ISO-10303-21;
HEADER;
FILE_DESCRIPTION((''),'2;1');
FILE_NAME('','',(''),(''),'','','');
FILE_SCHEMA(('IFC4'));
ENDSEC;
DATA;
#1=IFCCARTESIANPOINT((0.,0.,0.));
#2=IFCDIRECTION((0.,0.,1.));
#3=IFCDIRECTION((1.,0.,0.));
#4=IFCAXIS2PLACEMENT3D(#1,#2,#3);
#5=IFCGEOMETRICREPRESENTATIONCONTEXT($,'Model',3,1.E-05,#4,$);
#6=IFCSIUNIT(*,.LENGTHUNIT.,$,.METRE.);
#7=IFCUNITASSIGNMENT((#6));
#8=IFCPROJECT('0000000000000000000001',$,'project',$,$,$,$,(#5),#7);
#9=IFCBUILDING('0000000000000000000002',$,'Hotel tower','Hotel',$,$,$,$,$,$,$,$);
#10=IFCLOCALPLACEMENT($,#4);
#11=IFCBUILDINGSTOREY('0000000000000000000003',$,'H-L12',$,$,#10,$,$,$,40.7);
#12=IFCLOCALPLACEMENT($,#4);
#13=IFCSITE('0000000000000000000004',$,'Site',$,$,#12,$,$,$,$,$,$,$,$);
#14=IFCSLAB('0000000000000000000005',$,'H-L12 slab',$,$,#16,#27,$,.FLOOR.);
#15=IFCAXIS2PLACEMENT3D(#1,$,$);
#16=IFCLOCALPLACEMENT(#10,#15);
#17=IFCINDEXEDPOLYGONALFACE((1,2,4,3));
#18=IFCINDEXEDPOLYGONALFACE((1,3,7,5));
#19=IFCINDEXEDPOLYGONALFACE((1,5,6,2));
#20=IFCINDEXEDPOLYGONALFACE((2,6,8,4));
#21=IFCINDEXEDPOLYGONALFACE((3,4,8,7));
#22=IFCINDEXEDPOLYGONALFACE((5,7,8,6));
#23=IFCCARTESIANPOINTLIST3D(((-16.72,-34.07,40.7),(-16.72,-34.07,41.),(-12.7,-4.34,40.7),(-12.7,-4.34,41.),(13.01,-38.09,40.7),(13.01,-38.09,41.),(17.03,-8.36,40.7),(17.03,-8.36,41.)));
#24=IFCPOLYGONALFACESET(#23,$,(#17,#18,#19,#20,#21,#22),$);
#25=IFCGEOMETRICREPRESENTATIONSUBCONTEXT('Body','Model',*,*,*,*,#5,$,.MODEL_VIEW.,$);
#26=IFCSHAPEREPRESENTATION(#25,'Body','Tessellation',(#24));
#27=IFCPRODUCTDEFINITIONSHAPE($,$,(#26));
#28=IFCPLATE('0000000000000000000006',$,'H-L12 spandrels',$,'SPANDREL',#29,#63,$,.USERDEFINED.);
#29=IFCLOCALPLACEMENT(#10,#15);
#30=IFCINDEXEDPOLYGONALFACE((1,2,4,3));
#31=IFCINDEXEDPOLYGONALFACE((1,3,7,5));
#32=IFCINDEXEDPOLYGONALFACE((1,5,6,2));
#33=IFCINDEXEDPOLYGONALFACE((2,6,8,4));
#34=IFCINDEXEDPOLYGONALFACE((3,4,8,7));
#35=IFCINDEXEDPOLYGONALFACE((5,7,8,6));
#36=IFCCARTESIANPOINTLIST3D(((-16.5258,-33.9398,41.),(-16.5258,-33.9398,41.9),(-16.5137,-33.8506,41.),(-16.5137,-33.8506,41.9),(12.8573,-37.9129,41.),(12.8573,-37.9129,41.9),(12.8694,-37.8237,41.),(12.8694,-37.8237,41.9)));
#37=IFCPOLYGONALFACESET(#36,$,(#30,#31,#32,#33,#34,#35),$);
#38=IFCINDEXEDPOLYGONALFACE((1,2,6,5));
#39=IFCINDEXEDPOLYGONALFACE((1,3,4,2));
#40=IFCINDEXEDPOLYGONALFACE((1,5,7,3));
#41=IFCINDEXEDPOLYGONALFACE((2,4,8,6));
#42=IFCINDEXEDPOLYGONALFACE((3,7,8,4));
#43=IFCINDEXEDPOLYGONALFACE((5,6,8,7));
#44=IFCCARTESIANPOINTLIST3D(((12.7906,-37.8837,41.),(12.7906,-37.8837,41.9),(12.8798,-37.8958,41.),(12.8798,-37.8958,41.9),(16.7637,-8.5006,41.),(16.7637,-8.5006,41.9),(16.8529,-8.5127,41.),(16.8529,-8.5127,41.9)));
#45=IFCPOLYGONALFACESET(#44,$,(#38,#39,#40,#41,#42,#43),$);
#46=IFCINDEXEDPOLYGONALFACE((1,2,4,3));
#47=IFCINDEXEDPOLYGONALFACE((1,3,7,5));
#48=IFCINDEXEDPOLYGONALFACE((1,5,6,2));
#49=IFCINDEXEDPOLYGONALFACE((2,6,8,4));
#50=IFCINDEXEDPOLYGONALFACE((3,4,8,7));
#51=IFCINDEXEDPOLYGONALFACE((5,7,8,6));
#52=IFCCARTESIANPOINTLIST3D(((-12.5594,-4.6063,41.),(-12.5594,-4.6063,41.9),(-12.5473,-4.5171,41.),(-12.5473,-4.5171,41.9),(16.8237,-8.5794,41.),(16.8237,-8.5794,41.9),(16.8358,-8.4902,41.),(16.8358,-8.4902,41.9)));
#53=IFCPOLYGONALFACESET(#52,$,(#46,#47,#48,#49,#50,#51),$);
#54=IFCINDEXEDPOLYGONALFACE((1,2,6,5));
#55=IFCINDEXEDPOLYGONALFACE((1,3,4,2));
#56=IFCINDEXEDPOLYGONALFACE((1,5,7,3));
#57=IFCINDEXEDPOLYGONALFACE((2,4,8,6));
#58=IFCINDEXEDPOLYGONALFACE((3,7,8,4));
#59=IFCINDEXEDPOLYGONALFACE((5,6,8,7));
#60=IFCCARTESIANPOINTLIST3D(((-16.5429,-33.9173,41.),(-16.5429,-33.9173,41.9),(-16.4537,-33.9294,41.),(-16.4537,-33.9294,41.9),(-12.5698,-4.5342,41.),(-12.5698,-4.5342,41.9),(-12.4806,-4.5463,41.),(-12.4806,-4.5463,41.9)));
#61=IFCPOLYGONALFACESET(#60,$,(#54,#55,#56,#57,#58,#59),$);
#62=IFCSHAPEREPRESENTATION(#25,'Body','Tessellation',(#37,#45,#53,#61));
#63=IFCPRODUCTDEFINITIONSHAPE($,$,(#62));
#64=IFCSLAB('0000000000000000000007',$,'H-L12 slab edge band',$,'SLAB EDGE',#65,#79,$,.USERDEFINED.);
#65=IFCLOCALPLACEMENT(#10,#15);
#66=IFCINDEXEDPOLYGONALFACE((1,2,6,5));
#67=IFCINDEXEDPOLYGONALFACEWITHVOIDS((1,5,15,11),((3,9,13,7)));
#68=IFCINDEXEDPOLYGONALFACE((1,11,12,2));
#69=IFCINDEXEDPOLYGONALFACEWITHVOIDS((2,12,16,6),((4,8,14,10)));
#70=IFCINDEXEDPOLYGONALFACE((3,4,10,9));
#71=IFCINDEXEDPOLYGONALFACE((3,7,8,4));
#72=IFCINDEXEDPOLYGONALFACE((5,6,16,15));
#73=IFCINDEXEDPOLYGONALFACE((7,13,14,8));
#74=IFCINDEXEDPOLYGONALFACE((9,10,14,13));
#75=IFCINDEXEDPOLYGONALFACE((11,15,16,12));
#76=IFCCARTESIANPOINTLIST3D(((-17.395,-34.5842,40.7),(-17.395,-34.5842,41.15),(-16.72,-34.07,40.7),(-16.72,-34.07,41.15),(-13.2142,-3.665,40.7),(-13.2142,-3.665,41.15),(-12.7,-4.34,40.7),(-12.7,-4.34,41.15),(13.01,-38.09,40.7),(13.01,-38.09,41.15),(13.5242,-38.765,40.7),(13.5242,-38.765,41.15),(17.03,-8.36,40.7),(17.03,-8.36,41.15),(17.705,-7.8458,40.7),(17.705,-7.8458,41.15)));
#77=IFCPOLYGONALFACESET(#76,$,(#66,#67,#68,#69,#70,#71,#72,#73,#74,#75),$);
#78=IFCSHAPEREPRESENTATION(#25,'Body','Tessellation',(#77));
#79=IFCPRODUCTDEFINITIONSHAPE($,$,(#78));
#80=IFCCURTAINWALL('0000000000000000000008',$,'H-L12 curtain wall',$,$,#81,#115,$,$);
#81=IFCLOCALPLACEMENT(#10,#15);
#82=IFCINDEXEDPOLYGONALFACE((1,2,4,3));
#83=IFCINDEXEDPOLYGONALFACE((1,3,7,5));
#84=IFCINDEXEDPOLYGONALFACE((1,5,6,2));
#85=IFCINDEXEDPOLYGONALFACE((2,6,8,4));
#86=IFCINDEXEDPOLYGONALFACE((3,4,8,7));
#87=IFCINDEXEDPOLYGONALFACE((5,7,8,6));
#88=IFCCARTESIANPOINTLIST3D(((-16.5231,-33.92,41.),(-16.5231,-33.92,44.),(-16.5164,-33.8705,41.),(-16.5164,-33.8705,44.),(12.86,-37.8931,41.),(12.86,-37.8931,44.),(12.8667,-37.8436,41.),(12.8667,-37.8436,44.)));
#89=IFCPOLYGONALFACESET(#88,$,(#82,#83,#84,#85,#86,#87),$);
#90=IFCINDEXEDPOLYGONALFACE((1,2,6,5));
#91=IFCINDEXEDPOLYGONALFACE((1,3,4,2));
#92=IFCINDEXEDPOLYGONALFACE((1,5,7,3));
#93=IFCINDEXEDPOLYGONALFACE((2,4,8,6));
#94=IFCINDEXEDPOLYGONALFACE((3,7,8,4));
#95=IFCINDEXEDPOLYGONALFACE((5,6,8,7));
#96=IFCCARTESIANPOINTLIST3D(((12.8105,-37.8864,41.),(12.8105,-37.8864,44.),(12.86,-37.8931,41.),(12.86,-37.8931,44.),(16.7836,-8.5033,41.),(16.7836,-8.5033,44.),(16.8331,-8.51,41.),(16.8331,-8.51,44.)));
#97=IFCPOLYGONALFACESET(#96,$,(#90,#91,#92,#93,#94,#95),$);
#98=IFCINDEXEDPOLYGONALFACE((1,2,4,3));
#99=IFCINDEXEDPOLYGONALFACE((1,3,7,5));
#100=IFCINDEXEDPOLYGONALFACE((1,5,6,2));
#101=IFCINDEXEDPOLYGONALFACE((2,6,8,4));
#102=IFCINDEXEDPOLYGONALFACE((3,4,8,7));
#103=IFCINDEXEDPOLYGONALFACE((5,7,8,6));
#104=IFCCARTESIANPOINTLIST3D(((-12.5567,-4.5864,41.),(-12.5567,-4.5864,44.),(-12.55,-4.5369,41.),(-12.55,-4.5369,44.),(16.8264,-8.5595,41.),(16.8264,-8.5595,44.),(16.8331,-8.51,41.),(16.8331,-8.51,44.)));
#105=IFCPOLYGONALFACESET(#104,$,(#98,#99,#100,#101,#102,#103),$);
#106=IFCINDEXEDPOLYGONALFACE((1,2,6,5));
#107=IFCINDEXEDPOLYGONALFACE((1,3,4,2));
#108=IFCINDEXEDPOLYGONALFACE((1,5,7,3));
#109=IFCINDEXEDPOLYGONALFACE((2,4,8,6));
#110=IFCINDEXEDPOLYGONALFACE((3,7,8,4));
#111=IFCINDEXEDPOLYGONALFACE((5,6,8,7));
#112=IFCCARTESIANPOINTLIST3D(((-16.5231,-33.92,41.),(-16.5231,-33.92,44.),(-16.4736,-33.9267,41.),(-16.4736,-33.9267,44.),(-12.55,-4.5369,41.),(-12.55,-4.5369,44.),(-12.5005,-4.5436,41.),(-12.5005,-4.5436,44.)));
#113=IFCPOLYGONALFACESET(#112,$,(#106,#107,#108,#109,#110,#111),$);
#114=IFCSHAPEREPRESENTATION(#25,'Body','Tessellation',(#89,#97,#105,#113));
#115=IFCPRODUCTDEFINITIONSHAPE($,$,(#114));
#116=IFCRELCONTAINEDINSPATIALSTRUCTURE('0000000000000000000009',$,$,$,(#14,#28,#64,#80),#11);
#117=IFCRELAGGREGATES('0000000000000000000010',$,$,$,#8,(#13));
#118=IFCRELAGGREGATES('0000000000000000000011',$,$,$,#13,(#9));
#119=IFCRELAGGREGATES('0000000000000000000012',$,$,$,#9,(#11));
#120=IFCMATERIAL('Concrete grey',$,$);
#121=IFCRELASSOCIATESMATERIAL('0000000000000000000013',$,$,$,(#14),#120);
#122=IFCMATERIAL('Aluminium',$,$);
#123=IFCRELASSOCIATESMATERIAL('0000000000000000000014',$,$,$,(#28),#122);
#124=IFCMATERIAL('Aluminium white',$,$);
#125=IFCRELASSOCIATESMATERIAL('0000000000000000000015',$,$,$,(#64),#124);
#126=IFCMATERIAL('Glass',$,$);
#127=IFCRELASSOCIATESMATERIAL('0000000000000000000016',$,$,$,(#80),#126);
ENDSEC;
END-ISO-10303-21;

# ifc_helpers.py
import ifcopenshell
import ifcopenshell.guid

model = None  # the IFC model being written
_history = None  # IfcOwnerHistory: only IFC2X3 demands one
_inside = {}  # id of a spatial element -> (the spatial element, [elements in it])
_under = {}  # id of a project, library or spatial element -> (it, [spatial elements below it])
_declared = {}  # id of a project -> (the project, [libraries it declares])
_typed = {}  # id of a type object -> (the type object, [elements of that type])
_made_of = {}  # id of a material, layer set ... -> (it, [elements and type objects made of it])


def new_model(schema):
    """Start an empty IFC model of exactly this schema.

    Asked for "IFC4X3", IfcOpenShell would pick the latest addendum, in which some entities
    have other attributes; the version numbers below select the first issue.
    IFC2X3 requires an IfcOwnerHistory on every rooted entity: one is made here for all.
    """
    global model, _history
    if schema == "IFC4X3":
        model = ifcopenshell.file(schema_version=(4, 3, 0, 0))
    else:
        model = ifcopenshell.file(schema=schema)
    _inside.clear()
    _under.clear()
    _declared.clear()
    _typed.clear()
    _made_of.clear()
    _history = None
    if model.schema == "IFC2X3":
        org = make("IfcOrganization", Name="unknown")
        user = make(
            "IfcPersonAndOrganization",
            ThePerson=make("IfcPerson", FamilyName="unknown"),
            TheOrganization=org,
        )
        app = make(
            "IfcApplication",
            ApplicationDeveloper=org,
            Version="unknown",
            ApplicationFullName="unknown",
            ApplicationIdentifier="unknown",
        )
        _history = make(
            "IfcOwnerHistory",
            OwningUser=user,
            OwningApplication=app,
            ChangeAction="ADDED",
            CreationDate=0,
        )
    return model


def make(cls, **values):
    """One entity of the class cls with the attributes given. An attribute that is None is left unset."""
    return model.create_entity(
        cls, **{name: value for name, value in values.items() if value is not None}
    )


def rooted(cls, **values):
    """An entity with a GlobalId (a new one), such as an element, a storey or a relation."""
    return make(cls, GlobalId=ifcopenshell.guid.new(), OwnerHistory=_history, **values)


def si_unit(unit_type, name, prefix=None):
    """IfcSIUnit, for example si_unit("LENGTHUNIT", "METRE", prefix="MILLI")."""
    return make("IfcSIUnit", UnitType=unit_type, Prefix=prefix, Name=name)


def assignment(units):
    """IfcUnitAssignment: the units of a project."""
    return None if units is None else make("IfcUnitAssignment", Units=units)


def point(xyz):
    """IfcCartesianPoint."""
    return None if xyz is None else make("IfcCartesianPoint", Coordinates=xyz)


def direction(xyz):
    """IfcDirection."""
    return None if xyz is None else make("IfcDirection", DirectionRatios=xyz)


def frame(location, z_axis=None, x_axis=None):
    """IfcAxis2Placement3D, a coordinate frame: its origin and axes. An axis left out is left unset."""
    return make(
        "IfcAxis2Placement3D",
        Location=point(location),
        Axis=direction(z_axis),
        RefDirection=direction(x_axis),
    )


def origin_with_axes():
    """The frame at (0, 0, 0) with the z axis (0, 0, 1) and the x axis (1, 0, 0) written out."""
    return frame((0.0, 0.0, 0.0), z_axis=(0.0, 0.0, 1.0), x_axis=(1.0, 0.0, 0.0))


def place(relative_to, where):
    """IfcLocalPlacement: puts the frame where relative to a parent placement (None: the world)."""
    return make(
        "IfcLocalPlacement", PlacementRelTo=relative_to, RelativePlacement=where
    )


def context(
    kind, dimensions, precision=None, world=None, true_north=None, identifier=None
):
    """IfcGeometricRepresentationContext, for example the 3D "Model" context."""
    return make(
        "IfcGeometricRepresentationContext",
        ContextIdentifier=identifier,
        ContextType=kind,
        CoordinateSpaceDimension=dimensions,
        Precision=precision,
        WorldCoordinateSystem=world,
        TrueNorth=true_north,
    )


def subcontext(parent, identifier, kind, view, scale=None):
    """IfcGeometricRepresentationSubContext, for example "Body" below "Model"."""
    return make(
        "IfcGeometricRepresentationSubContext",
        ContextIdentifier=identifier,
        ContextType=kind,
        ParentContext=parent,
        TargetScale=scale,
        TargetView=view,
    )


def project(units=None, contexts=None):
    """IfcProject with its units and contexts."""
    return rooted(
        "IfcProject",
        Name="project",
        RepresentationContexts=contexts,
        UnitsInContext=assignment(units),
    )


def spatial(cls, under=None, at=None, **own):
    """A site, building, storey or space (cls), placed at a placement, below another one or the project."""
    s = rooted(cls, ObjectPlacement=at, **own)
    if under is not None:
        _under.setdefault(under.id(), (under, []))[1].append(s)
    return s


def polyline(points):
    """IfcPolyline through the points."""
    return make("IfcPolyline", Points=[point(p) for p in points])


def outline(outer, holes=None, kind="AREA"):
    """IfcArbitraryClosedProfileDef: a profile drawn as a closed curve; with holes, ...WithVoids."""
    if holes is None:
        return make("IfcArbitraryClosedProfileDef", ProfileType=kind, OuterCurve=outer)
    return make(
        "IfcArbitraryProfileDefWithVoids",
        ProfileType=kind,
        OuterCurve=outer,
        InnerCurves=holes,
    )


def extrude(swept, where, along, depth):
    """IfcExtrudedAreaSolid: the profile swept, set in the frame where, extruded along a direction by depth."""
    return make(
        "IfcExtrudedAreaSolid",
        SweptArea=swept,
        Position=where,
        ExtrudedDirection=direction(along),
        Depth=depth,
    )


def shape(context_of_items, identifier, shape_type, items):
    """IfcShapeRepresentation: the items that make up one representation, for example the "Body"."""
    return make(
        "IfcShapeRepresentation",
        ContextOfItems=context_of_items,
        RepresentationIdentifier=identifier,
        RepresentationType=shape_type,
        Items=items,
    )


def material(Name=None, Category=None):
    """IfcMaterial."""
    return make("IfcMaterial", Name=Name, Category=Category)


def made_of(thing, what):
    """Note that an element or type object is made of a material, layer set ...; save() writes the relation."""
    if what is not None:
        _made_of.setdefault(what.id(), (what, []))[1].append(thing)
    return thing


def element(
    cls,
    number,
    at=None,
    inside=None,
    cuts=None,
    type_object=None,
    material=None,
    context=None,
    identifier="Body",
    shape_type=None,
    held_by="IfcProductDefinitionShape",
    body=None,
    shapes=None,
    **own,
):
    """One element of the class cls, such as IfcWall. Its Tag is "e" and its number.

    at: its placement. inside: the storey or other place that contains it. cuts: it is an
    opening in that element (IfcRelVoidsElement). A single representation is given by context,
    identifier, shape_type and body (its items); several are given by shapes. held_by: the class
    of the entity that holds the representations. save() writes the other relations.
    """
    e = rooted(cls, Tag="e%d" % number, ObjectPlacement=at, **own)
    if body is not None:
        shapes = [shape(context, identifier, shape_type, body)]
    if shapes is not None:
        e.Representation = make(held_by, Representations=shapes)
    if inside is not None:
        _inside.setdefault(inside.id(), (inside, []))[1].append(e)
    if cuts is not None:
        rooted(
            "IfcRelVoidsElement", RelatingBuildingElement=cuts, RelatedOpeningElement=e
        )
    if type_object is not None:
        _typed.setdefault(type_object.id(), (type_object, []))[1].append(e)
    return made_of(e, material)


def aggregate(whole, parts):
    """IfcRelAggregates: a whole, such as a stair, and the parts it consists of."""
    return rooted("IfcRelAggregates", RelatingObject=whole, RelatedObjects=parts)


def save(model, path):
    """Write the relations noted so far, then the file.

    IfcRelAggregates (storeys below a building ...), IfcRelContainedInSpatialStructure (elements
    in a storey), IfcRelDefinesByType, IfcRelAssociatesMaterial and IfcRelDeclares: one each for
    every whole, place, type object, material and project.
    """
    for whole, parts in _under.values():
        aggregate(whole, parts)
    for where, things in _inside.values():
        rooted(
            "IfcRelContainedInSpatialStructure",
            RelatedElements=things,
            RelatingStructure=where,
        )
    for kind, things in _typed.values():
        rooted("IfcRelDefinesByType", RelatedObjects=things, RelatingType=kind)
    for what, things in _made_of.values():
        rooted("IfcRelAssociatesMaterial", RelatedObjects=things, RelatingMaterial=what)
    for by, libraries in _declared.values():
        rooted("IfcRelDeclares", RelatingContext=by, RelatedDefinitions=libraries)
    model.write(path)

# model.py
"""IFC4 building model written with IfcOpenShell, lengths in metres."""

from ifc_helpers import new_model, si_unit, frame, origin_with_axes, place, context, subcontext, project, spatial, polyline, outline, extrude, material, element, save


model = new_model("IFC4")

# Units and contexts
model_context = context("Model", 3, precision=1e-05, world=origin_with_axes())
body_context = subcontext(model_context, "Body", "Model", "MODEL_VIEW")
ifc_project = project(units=[si_unit("LENGTHUNIT", "METRE")], contexts=[model_context])

# Site, building, storey
site_placement = place(None, origin_with_axes())
site = spatial("IfcSite", under=ifc_project, at=site_placement, Name="Site")
building = spatial("IfcBuilding", under=site, Name="Hotel tower", Description="Hotel")
storey_placement = place(None, origin_with_axes())
storey = spatial("IfcBuildingStorey", under=building, at=storey_placement, Name="H-L12", Elevation=40.7)

# Shared definitions
ifc_material_1 = material(Name="Aluminium")

# Slab
ifc_material_2 = material(Name="Concrete grey")
slab_1_placement = place(storey_placement, origin_with_axes())
element("IfcSlab", 1, at=slab_1_placement, inside=storey, material=ifc_material_2, Name="H-L12 slab", PredefinedType="FLOOR", context=body_context, shape_type="SweptSolid", body=[
    extrude(outline(polyline([(-16.72, -34.07), (13.01, -38.09), (17.03, -8.36), (-12.7, -4.34), (-16.72, -34.07)])), frame((0.0, 0.0, 40.7), z_axis=(0.0, 0.0, 1.0), x_axis=(1.0, 0.0, 0.0)), (0.0, 0.0, 1.0), 0.3),
])

# Plate
plate_placement = place(storey_placement, origin_with_axes())
element("IfcPlate", 2, at=plate_placement, inside=storey, material=ifc_material_1, Name="H-L12 spandrels", ObjectType="SPANDREL", PredefinedType="USERDEFINED", context=body_context, shape_type="SweptSolid", body=[
    extrude(outline(polyline([(-16.5258, -33.9398), (12.8573, -37.9129), (12.8694, -37.8237), (-16.5137, -33.8506), (-16.5258, -33.9398)])), frame((0.0, 0.0, 41.0), z_axis=(0.0, 0.0, 1.0), x_axis=(1.0, 0.0, 0.0)), (0.0, 0.0, 1.0), 0.9),
    extrude(outline(polyline([(12.8798, -37.8958), (16.8529, -8.5127), (16.7637, -8.5006), (12.7906, -37.8837), (12.8798, -37.8958)])), frame((0.0, 0.0, 41.0), z_axis=(0.0, 0.0, 1.0), x_axis=(1.0, 0.0, 0.0)), (0.0, 0.0, 1.0), 0.9),
    extrude(outline(polyline([(16.8358, -8.4902), (-12.5473, -4.5171), (-12.5594, -4.6063), (16.8237, -8.5794), (16.8358, -8.4902)])), frame((0.0, 0.0, 41.0), z_axis=(0.0, 0.0, 1.0), x_axis=(1.0, 0.0, 0.0)), (0.0, 0.0, 1.0), 0.9),
    extrude(outline(polyline([(-12.5698, -4.5342), (-16.5429, -33.9173), (-16.4537, -33.9294), (-12.4806, -4.5463), (-12.5698, -4.5342)])), frame((0.0, 0.0, 41.0), z_axis=(0.0, 0.0, 1.0), x_axis=(1.0, 0.0, 0.0)), (0.0, 0.0, 1.0), 0.9),
])

# Slab
ifc_material_3 = material(Name="Aluminium white")
slab_2_placement = place(storey_placement, origin_with_axes())
element("IfcSlab", 3, at=slab_2_placement, inside=storey, material=ifc_material_3, Name="H-L12 slab edge band", ObjectType="SLAB EDGE", PredefinedType="USERDEFINED", context=body_context, shape_type="SweptSolid", body=[
    extrude(outline(polyline([(-17.395, -34.5842), (13.5242, -38.765), (17.705, -7.8458), (-13.2142, -3.665), (-17.395, -34.5842)]), holes=[polyline([(-16.72, -34.07), (13.01, -38.09), (17.03, -8.36), (-12.7, -4.34), (-16.72, -34.07)])]), frame((0.0, 0.0, 40.7), z_axis=(0.0, 0.0, 1.0), x_axis=(1.0, 0.0, 0.0)), (0.0, 0.0, 1.0), 0.45),
])

# Curtain wall
ifc_material_4 = material(Name="Glass")
curtain_wall_placement = place(storey_placement, origin_with_axes())
element("IfcCurtainWall", 4, at=curtain_wall_placement, inside=storey, material=ifc_material_4, Name="H-L12 curtain wall", context=body_context, shape_type="SweptSolid", body=[
    extrude(outline(polyline([(-16.5231, -33.92), (12.86, -37.8931), (12.8667, -37.8436), (-16.5164, -33.8705), (-16.5231, -33.92)])), frame((0.0, 0.0, 41.0), z_axis=(0.0, 0.0, 1.0), x_axis=(1.0, 0.0, 0.0)), (0.0, 0.0, 1.0), 3.0),
    extrude(outline(polyline([(12.86, -37.8931), (16.8331, -8.51), (16.7836, -8.5033), (12.8105, -37.8864), (12.86, -37.8931)])), frame((0.0, 0.0, 41.0), z_axis=(0.0, 0.0, 1.0), x_axis=(1.0, 0.0, 0.0)), (0.0, 0.0, 1.0), 3.0),
    extrude(outline(polyline([(16.8331, -8.51), (-12.55, -4.5369), (-12.5567, -4.5864), (16.8264, -8.5595), (16.8331, -8.51)])), frame((0.0, 0.0, 41.0), z_axis=(0.0, 0.0, 1.0), x_axis=(1.0, 0.0, 0.0)), (0.0, 0.0, 1.0), 3.0),
    extrude(outline(polyline([(-12.55, -4.5369), (-16.5231, -33.92), (-16.4736, -33.9267), (-12.5005, -4.5436), (-12.55, -4.5369)])), frame((0.0, 0.0, 41.0), z_axis=(0.0, 0.0, 1.0), x_axis=(1.0, 0.0, 0.0)), (0.0, 0.0, 1.0), 3.0),
])

save(model, "model.ifc")
